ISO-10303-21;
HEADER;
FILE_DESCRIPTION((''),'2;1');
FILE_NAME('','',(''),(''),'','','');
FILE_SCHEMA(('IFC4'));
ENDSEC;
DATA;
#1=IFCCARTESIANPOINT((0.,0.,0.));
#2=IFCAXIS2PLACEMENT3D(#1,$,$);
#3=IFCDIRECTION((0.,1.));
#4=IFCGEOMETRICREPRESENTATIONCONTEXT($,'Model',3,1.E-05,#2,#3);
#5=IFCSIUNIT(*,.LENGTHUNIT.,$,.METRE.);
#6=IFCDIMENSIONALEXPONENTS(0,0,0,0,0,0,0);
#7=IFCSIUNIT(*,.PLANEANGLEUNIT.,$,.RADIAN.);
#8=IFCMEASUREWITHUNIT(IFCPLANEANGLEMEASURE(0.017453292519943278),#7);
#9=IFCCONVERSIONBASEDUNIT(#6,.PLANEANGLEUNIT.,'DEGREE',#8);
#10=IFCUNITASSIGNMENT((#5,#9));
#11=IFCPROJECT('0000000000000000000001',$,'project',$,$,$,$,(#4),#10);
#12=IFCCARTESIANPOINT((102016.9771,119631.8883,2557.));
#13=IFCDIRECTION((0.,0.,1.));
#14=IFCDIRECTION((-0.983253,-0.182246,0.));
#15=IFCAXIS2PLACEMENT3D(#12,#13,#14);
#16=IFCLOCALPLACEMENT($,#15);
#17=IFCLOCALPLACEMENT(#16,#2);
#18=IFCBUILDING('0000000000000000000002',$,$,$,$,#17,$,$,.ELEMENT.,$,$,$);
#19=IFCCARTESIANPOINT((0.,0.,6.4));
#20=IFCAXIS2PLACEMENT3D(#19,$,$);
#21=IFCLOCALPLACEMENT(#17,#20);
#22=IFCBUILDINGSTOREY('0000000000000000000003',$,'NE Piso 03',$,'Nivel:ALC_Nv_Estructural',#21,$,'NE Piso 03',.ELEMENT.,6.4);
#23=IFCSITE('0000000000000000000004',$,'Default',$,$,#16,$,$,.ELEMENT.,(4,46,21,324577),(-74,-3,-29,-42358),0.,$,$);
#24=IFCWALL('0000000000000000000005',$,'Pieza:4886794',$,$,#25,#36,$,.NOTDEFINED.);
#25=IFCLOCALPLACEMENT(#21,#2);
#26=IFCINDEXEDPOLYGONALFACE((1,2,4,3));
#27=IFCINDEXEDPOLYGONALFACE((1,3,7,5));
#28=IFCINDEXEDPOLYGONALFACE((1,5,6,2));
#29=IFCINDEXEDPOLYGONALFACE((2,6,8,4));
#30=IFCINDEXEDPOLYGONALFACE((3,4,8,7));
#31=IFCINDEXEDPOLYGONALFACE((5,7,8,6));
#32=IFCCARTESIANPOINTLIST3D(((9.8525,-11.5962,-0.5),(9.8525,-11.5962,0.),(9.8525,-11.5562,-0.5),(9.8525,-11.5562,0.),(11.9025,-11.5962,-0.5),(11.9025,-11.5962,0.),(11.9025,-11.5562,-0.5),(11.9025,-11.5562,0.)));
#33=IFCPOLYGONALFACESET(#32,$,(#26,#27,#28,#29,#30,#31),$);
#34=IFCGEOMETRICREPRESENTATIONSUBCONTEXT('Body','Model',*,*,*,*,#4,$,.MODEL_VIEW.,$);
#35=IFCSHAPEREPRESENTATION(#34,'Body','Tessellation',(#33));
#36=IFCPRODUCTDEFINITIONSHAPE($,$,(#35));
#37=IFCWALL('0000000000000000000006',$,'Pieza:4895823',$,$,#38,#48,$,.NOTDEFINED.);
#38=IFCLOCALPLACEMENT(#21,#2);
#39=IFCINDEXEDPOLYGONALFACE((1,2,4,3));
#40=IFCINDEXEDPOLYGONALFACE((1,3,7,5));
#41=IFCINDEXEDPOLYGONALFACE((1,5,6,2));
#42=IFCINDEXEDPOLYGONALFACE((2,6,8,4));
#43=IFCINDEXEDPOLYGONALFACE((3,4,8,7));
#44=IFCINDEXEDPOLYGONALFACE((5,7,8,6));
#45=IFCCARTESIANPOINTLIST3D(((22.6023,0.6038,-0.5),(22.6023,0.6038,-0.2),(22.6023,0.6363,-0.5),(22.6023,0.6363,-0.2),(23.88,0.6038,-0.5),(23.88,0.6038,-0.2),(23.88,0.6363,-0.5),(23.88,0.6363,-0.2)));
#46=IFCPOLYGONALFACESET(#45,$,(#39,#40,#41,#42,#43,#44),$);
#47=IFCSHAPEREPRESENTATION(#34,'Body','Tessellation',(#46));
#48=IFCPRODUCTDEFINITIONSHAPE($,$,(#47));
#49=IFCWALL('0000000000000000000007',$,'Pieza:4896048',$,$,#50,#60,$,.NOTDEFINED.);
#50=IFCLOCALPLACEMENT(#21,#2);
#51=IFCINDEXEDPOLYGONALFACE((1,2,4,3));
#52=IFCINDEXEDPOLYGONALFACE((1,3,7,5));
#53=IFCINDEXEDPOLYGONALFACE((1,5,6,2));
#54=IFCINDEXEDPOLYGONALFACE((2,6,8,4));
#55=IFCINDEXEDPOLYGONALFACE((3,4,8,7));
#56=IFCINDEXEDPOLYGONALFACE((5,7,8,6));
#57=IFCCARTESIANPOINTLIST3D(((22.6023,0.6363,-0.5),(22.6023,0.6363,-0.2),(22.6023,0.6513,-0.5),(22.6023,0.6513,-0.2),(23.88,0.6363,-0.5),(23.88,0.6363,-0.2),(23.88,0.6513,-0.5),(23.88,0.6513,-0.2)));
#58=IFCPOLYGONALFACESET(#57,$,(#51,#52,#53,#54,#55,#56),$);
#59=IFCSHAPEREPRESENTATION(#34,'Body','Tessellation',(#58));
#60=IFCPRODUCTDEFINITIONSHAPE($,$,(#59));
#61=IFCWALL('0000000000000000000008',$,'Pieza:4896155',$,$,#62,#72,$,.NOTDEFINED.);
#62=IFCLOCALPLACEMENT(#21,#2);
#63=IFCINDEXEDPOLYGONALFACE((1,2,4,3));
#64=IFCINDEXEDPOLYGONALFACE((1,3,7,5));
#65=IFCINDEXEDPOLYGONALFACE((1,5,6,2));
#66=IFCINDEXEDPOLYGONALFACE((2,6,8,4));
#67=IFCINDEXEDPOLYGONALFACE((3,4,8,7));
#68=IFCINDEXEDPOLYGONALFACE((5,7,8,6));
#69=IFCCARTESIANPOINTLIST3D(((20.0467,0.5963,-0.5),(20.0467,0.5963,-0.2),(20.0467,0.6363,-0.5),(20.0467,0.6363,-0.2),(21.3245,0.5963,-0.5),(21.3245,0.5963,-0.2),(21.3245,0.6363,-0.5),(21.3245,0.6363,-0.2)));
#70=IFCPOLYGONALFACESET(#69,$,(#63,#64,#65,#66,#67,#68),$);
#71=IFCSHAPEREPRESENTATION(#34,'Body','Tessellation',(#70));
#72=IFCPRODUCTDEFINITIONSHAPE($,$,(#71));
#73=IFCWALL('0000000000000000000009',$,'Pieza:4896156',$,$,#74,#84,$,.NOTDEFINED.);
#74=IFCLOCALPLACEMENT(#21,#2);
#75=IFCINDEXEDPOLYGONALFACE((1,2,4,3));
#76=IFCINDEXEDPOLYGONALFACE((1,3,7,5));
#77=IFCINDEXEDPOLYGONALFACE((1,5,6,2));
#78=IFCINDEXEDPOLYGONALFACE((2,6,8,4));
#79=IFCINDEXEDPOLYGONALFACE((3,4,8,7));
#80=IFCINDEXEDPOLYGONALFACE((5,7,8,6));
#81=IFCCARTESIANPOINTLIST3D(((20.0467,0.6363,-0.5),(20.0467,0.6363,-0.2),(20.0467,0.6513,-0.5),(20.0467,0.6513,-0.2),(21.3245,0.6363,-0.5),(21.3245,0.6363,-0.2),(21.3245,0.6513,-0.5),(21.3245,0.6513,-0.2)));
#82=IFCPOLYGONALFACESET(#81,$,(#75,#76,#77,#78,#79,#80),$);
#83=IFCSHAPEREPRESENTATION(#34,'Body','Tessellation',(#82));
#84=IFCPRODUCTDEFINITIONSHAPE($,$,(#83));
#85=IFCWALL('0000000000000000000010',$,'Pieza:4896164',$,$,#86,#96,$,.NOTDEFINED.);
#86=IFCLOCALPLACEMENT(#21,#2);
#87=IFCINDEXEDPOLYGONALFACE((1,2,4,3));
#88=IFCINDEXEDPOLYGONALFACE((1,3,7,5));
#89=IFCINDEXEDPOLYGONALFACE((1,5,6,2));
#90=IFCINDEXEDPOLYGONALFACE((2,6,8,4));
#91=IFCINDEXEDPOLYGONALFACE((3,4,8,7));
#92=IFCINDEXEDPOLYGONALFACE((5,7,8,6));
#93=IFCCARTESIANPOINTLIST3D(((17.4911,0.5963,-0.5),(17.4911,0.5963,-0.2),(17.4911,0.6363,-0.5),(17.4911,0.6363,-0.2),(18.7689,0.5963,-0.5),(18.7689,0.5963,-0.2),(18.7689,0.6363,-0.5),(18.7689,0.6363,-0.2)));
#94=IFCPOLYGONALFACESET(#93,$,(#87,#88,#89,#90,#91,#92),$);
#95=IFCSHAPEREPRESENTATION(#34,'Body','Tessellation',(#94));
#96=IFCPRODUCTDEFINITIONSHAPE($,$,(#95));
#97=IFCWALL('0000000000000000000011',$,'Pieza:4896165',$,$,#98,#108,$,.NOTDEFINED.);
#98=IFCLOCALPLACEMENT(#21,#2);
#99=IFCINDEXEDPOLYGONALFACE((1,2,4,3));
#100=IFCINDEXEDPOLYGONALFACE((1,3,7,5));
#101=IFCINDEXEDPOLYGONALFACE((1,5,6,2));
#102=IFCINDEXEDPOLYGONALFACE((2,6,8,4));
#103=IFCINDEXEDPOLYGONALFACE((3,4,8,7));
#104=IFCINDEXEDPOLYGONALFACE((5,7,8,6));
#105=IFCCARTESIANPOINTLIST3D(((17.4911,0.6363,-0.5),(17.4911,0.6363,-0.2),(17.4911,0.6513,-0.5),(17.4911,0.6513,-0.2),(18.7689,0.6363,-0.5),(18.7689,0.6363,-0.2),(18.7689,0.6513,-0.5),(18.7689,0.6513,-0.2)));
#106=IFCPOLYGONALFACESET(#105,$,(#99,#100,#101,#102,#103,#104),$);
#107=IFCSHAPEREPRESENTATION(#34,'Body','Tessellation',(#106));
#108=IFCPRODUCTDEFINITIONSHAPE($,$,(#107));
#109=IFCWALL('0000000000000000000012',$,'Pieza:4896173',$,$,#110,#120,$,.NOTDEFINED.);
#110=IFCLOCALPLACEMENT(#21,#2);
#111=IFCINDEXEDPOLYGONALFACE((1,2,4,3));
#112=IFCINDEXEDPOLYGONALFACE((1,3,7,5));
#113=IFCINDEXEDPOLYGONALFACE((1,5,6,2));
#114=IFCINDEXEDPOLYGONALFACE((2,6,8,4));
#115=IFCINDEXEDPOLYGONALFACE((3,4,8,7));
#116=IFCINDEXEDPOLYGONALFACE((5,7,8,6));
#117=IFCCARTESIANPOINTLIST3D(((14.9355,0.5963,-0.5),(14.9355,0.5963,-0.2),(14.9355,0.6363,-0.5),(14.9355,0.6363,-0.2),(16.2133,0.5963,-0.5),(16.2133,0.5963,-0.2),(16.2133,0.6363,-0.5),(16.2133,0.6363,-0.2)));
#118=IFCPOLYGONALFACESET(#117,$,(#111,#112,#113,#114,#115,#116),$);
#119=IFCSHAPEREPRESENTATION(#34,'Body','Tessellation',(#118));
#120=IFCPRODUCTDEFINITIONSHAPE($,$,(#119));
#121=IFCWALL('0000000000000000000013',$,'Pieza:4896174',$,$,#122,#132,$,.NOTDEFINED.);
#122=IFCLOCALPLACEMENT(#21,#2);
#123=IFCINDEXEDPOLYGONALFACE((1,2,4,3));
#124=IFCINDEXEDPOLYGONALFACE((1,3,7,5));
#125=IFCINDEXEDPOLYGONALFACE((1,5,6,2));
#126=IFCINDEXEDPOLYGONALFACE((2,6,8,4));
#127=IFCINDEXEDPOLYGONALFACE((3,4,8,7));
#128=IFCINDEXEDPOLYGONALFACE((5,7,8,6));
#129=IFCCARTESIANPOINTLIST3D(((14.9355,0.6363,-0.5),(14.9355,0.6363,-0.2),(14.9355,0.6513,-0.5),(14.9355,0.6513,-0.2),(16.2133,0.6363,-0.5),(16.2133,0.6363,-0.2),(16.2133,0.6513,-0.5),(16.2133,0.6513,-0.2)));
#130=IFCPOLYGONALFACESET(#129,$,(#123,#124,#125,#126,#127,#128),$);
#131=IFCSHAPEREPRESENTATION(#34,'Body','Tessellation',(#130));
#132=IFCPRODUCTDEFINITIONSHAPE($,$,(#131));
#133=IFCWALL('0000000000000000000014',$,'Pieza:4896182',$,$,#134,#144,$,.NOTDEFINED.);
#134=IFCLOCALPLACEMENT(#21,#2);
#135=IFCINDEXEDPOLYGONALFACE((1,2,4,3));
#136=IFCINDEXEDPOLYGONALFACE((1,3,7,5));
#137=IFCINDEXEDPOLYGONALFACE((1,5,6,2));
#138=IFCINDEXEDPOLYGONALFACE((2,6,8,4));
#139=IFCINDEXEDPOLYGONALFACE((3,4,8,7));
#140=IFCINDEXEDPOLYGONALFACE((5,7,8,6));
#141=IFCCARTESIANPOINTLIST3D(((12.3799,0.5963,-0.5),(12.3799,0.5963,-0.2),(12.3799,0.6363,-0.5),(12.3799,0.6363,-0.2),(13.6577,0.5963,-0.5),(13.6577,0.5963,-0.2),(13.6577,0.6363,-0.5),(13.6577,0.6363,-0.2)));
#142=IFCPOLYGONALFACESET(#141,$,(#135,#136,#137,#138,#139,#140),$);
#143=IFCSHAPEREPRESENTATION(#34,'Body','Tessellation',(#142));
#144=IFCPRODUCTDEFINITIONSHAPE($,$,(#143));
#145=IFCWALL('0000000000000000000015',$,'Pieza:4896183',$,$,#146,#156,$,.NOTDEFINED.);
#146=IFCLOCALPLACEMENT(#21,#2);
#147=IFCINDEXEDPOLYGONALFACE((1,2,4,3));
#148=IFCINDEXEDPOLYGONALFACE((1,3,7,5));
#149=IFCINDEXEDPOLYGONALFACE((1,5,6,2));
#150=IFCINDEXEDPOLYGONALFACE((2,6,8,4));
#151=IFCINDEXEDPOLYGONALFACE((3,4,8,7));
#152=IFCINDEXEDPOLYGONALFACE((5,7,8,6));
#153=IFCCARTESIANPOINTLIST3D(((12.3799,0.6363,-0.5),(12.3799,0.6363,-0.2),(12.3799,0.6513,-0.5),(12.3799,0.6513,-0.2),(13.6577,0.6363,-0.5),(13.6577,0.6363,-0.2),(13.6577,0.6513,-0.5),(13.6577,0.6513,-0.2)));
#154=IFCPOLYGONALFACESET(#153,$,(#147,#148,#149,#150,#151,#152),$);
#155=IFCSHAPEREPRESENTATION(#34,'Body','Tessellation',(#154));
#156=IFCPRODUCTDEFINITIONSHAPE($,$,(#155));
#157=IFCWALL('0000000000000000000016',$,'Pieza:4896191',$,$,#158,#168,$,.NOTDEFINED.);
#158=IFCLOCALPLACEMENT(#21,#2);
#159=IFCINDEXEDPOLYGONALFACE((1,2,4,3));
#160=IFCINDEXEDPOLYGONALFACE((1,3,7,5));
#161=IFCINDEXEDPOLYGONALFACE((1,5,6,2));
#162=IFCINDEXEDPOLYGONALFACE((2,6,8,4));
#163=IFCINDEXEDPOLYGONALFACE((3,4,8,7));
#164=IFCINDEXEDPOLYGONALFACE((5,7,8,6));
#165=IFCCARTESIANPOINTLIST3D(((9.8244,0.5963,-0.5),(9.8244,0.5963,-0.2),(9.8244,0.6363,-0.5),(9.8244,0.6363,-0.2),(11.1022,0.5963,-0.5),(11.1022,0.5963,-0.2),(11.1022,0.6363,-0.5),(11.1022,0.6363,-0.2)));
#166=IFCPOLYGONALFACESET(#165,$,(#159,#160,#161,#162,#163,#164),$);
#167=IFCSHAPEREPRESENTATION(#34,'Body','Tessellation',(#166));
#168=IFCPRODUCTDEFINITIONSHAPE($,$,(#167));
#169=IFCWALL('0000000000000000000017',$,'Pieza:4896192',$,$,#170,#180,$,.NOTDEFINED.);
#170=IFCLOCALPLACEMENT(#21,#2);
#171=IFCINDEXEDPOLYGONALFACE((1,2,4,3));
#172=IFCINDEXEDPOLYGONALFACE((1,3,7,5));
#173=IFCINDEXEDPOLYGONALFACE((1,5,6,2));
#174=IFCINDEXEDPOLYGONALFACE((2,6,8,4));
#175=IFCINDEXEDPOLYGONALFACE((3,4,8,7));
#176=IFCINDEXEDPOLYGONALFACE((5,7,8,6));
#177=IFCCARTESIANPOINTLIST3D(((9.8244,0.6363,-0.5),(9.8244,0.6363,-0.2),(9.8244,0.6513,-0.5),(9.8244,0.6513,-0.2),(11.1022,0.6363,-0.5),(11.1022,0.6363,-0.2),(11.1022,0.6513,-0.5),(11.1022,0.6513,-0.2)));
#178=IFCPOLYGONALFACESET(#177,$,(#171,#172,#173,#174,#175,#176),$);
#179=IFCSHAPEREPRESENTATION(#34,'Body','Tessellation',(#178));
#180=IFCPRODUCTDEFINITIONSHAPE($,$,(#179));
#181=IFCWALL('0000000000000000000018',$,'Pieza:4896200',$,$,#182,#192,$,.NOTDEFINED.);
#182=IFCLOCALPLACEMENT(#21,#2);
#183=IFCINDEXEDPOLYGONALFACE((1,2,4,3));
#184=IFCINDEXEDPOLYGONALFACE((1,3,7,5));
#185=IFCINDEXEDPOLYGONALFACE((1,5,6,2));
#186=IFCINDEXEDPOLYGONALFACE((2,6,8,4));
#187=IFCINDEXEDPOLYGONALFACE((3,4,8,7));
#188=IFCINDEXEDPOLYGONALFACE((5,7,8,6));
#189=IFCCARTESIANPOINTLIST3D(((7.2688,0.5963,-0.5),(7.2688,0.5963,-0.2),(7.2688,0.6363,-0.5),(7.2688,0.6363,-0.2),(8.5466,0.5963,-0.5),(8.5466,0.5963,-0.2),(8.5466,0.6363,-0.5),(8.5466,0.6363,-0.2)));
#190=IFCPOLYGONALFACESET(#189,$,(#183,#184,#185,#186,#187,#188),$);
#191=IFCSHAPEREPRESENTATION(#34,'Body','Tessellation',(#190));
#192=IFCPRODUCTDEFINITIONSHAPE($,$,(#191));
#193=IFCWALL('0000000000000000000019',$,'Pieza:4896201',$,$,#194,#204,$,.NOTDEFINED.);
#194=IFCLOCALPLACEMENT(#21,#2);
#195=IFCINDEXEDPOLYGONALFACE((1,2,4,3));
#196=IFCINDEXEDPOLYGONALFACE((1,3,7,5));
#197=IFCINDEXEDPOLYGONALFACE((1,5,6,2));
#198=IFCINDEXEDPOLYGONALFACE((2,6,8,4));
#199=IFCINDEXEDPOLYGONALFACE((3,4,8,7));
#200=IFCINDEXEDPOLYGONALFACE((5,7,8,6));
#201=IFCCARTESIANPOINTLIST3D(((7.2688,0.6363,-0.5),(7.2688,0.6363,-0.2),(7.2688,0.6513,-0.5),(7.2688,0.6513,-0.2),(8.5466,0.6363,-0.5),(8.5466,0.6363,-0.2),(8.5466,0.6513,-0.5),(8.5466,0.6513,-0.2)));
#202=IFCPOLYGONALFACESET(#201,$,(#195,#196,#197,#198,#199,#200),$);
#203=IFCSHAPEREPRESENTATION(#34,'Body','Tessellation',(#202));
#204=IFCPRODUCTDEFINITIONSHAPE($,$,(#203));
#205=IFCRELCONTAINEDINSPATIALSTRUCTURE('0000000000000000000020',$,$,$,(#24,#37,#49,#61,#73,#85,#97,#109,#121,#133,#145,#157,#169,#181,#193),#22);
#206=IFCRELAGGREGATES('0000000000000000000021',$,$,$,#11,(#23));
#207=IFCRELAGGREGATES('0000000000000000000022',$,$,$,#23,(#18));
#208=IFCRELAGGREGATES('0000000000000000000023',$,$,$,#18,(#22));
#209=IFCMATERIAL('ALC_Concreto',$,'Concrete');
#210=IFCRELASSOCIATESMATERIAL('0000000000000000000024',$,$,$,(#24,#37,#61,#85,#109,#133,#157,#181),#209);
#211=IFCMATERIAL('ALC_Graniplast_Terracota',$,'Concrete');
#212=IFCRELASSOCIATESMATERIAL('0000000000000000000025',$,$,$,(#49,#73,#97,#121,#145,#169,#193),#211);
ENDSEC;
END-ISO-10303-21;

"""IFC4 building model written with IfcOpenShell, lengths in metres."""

from ifc_helpers import new_model, entity, si_unit, converted_unit, direction, frame, frame_2d, origin, origin_2d_with_axis, place, context, subcontext, project, spatial, rectangle, extrude, material, element, save


model = new_model("IFC4")

# Units and contexts
model_context = context("Model", 3, precision=1e-05, world=origin(), true_north=direction((0.0, 1.0)))
body_context = subcontext(model_context, "Body", "Model", "MODEL_VIEW")
ifc_project = project(units=[si_unit("LENGTHUNIT", "METRE"), converted_unit("PLANEANGLEUNIT", "DEGREE", entity("IfcPlaneAngleMeasure", 0.017453292519943278), si_unit("PLANEANGLEUNIT", "RADIAN"), dimensions=[0, 0, 0, 0, 0, 0, 0])], contexts=[model_context])

# Site, building, storey
site_placement = place(None, frame((102016.9771, 119631.8883, 2557.0), z_axis=(0.0, 0.0, 1.0), x_axis=(-0.983253, -0.182246, 0.0)))
site = spatial("IfcSite", under=ifc_project, at=site_placement, Name="Default", CompositionType="ELEMENT", RefLatitude=(4, 46, 21, 324577), RefLongitude=(-74, -3, -29, -42358), RefElevation=0.0)
building_placement = place(site_placement, origin())
building = spatial("IfcBuilding", under=site, at=building_placement, CompositionType="ELEMENT")
storey_placement = place(building_placement, frame((0.0, 0.0, 6.4)))
storey = spatial("IfcBuildingStorey", under=building, at=storey_placement, Name="NE Piso 03", ObjectType="Nivel:ALC_Nv_Estructural", LongName="NE Piso 03", CompositionType="ELEMENT", Elevation=6.4)

# Walls
ifc_material_1 = material(Name="ALC_Concreto", Category="Concrete")
ifc_material_2 = material(Name="ALC_Graniplast_Terracota", Category="Concrete")
wall_1_placement = place(storey_placement, frame((0.0, 0.0, -0.5)))
element("IfcWall", 1, at=wall_1_placement, inside=storey, material=ifc_material_1, Name="Pieza:4886794", PredefinedType="NOTDEFINED", context=body_context, shape_type="SweptSolid", body=[
    extrude(rectangle(XDim=0.04, YDim=2.05, at=frame_2d((0.0, 0.0), x_axis=(1.0, 0.0))), frame((10.8775, -11.5762, 0.0), z_axis=(0.0, 0.0, 1.0), x_axis=(0.0, -1.0, 0.0)), (0.0, 0.0, 1.0), 0.5),
])
wall_2_placement = place(storey_placement, frame((0.0, 0.0, -0.5)))
element("IfcWall", 2, at=wall_2_placement, inside=storey, material=ifc_material_1, Name="Pieza:4895823", PredefinedType="NOTDEFINED", context=body_context, shape_type="SweptSolid", body=[
    extrude(rectangle(XDim=0.0325, YDim=1.2778, at=frame_2d((0.0, 0.0), x_axis=(1.0, 0.0))), frame((23.2412, 0.6201, 0.0), z_axis=(0.0, 0.0, 1.0), x_axis=(0.0, -1.0, 0.0)), (0.0, 0.0, 1.0), 0.3),
])
wall_3_placement = place(storey_placement, frame((0.0, 0.0, -0.5)))
element("IfcWall", 3, at=wall_3_placement, inside=storey, material=ifc_material_2, Name="Pieza:4896048", PredefinedType="NOTDEFINED", context=body_context, shape_type="SweptSolid", body=[
    extrude(rectangle(XDim=0.015, YDim=1.2778, at=origin_2d_with_axis()), frame((23.2412, 0.6438, 0.0), z_axis=(0.0, 0.0, 1.0), x_axis=(0.0, -1.0, 0.0)), (0.0, 0.0, 1.0), 0.3),
])
wall_4_placement = place(storey_placement, frame((0.0, 0.0, -0.5)))
element("IfcWall", 4, at=wall_4_placement, inside=storey, material=ifc_material_1, Name="Pieza:4896155", PredefinedType="NOTDEFINED", context=body_context, shape_type="SweptSolid", body=[
    extrude(rectangle(XDim=0.04, YDim=1.2778, at=frame_2d((0.0, 0.0), x_axis=(1.0, 0.0))), frame((20.6856, 0.6163, 0.0), z_axis=(0.0, 0.0, 1.0), x_axis=(0.0, -1.0, 0.0)), (0.0, 0.0, 1.0), 0.3),
])
wall_5_placement = place(storey_placement, frame((0.0, 0.0, -0.5)))
element("IfcWall", 5, at=wall_5_placement, inside=storey, material=ifc_material_2, Name="Pieza:4896156", PredefinedType="NOTDEFINED", context=body_context, shape_type="SweptSolid", body=[
    extrude(rectangle(XDim=0.015, YDim=1.2778, at=origin_2d_with_axis()), frame((20.6856, 0.6438, 0.0), z_axis=(0.0, 0.0, 1.0), x_axis=(0.0, -1.0, 0.0)), (0.0, 0.0, 1.0), 0.3),
])
wall_6_placement = place(storey_placement, frame((0.0, 0.0, -0.5)))
element("IfcWall", 6, at=wall_6_placement, inside=storey, material=ifc_material_1, Name="Pieza:4896164", PredefinedType="NOTDEFINED", context=body_context, shape_type="SweptSolid", body=[
    extrude(rectangle(XDim=0.04, YDim=1.2778, at=frame_2d((0.0, 0.0), x_axis=(1.0, 0.0))), frame((18.13, 0.6163, 0.0), z_axis=(0.0, 0.0, 1.0), x_axis=(0.0, -1.0, 0.0)), (0.0, 0.0, 1.0), 0.3),
])
wall_7_placement = place(storey_placement, frame((0.0, 0.0, -0.5)))
element("IfcWall", 7, at=wall_7_placement, inside=storey, material=ifc_material_2, Name="Pieza:4896165", PredefinedType="NOTDEFINED", context=body_context, shape_type="SweptSolid", body=[
    extrude(rectangle(XDim=0.015, YDim=1.2778, at=origin_2d_with_axis()), frame((18.13, 0.6438, 0.0), z_axis=(0.0, 0.0, 1.0), x_axis=(0.0, -1.0, 0.0)), (0.0, 0.0, 1.0), 0.3),
])
wall_8_placement = place(storey_placement, frame((0.0, 0.0, -0.5)))
element("IfcWall", 8, at=wall_8_placement, inside=storey, material=ifc_material_1, Name="Pieza:4896173", PredefinedType="NOTDEFINED", context=body_context, shape_type="SweptSolid", body=[
    extrude(rectangle(XDim=0.04, YDim=1.2778, at=frame_2d((0.0, 0.0), x_axis=(1.0, 0.0))), frame((15.5744, 0.6163, 0.0), z_axis=(0.0, 0.0, 1.0), x_axis=(0.0, -1.0, 0.0)), (0.0, 0.0, 1.0), 0.3),
])
wall_9_placement = place(storey_placement, frame((0.0, 0.0, -0.5)))
element("IfcWall", 9, at=wall_9_placement, inside=storey, material=ifc_material_2, Name="Pieza:4896174", PredefinedType="NOTDEFINED", context=body_context, shape_type="SweptSolid", body=[
    extrude(rectangle(XDim=0.015, YDim=1.2778, at=origin_2d_with_axis()), frame((15.5744, 0.6438, 0.0), z_axis=(0.0, 0.0, 1.0), x_axis=(0.0, -1.0, 0.0)), (0.0, 0.0, 1.0), 0.3),
])
wall_10_placement = place(storey_placement, frame((0.0, 0.0, -0.5)))
element("IfcWall", 10, at=wall_10_placement, inside=storey, material=ifc_material_1, Name="Pieza:4896182", PredefinedType="NOTDEFINED", context=body_context, shape_type="SweptSolid", body=[
    extrude(rectangle(XDim=0.04, YDim=1.2778, at=frame_2d((0.0, 0.0), x_axis=(1.0, 0.0))), frame((13.0188, 0.6163, 0.0), z_axis=(0.0, 0.0, 1.0), x_axis=(0.0, -1.0, 0.0)), (0.0, 0.0, 1.0), 0.3),
])
wall_11_placement = place(storey_placement, frame((0.0, 0.0, -0.5)))
element("IfcWall", 11, at=wall_11_placement, inside=storey, material=ifc_material_2, Name="Pieza:4896183", PredefinedType="NOTDEFINED", context=body_context, shape_type="SweptSolid", body=[
    extrude(rectangle(XDim=0.015, YDim=1.2778, at=frame_2d((0.0, 0.0), x_axis=(1.0, 0.0))), frame((13.0188, 0.6438, 0.0), z_axis=(0.0, 0.0, 1.0), x_axis=(0.0, -1.0, 0.0)), (0.0, 0.0, 1.0), 0.3),
])
wall_12_placement = place(storey_placement, frame((0.0, 0.0, -0.5)))
element("IfcWall", 12, at=wall_12_placement, inside=storey, material=ifc_material_1, Name="Pieza:4896191", PredefinedType="NOTDEFINED", context=body_context, shape_type="SweptSolid", body=[
    extrude(rectangle(XDim=0.04, YDim=1.2778, at=frame_2d((0.0, 0.0), x_axis=(1.0, 0.0))), frame((10.4633, 0.6163, 0.0), z_axis=(0.0, 0.0, 1.0), x_axis=(0.0, -1.0, 0.0)), (0.0, 0.0, 1.0), 0.3),
])
wall_13_placement = place(storey_placement, frame((0.0, 0.0, -0.5)))
element("IfcWall", 13, at=wall_13_placement, inside=storey, material=ifc_material_2, Name="Pieza:4896192", PredefinedType="NOTDEFINED", context=body_context, shape_type="SweptSolid", body=[
    extrude(rectangle(XDim=0.015, YDim=1.2778, at=origin_2d_with_axis()), frame((10.4633, 0.6438, 0.0), z_axis=(0.0, 0.0, 1.0), x_axis=(0.0, -1.0, 0.0)), (0.0, 0.0, 1.0), 0.3),
])
wall_14_placement = place(storey_placement, frame((0.0, 0.0, -0.5)))
element("IfcWall", 14, at=wall_14_placement, inside=storey, material=ifc_material_1, Name="Pieza:4896200", PredefinedType="NOTDEFINED", context=body_context, shape_type="SweptSolid", body=[
    extrude(rectangle(XDim=0.04, YDim=1.2778, at=frame_2d((0.0, 0.0), x_axis=(1.0, 0.0))), frame((7.9077, 0.6163, 0.0), z_axis=(0.0, 0.0, 1.0), x_axis=(0.0, -1.0, 0.0)), (0.0, 0.0, 1.0), 0.3),
])
wall_15_placement = place(storey_placement, frame((0.0, 0.0, -0.5)))
element("IfcWall", 15, at=wall_15_placement, inside=storey, material=ifc_material_2, Name="Pieza:4896201", PredefinedType="NOTDEFINED", context=body_context, shape_type="SweptSolid", body=[
    extrude(rectangle(XDim=0.015, YDim=1.2778, at=origin_2d_with_axis()), frame((7.9077, 0.6438, 0.0), z_axis=(0.0, 0.0, 1.0), x_axis=(0.0, -1.0, 0.0)), (0.0, 0.0, 1.0), 0.3),
])

save(model, "model.ifc")
